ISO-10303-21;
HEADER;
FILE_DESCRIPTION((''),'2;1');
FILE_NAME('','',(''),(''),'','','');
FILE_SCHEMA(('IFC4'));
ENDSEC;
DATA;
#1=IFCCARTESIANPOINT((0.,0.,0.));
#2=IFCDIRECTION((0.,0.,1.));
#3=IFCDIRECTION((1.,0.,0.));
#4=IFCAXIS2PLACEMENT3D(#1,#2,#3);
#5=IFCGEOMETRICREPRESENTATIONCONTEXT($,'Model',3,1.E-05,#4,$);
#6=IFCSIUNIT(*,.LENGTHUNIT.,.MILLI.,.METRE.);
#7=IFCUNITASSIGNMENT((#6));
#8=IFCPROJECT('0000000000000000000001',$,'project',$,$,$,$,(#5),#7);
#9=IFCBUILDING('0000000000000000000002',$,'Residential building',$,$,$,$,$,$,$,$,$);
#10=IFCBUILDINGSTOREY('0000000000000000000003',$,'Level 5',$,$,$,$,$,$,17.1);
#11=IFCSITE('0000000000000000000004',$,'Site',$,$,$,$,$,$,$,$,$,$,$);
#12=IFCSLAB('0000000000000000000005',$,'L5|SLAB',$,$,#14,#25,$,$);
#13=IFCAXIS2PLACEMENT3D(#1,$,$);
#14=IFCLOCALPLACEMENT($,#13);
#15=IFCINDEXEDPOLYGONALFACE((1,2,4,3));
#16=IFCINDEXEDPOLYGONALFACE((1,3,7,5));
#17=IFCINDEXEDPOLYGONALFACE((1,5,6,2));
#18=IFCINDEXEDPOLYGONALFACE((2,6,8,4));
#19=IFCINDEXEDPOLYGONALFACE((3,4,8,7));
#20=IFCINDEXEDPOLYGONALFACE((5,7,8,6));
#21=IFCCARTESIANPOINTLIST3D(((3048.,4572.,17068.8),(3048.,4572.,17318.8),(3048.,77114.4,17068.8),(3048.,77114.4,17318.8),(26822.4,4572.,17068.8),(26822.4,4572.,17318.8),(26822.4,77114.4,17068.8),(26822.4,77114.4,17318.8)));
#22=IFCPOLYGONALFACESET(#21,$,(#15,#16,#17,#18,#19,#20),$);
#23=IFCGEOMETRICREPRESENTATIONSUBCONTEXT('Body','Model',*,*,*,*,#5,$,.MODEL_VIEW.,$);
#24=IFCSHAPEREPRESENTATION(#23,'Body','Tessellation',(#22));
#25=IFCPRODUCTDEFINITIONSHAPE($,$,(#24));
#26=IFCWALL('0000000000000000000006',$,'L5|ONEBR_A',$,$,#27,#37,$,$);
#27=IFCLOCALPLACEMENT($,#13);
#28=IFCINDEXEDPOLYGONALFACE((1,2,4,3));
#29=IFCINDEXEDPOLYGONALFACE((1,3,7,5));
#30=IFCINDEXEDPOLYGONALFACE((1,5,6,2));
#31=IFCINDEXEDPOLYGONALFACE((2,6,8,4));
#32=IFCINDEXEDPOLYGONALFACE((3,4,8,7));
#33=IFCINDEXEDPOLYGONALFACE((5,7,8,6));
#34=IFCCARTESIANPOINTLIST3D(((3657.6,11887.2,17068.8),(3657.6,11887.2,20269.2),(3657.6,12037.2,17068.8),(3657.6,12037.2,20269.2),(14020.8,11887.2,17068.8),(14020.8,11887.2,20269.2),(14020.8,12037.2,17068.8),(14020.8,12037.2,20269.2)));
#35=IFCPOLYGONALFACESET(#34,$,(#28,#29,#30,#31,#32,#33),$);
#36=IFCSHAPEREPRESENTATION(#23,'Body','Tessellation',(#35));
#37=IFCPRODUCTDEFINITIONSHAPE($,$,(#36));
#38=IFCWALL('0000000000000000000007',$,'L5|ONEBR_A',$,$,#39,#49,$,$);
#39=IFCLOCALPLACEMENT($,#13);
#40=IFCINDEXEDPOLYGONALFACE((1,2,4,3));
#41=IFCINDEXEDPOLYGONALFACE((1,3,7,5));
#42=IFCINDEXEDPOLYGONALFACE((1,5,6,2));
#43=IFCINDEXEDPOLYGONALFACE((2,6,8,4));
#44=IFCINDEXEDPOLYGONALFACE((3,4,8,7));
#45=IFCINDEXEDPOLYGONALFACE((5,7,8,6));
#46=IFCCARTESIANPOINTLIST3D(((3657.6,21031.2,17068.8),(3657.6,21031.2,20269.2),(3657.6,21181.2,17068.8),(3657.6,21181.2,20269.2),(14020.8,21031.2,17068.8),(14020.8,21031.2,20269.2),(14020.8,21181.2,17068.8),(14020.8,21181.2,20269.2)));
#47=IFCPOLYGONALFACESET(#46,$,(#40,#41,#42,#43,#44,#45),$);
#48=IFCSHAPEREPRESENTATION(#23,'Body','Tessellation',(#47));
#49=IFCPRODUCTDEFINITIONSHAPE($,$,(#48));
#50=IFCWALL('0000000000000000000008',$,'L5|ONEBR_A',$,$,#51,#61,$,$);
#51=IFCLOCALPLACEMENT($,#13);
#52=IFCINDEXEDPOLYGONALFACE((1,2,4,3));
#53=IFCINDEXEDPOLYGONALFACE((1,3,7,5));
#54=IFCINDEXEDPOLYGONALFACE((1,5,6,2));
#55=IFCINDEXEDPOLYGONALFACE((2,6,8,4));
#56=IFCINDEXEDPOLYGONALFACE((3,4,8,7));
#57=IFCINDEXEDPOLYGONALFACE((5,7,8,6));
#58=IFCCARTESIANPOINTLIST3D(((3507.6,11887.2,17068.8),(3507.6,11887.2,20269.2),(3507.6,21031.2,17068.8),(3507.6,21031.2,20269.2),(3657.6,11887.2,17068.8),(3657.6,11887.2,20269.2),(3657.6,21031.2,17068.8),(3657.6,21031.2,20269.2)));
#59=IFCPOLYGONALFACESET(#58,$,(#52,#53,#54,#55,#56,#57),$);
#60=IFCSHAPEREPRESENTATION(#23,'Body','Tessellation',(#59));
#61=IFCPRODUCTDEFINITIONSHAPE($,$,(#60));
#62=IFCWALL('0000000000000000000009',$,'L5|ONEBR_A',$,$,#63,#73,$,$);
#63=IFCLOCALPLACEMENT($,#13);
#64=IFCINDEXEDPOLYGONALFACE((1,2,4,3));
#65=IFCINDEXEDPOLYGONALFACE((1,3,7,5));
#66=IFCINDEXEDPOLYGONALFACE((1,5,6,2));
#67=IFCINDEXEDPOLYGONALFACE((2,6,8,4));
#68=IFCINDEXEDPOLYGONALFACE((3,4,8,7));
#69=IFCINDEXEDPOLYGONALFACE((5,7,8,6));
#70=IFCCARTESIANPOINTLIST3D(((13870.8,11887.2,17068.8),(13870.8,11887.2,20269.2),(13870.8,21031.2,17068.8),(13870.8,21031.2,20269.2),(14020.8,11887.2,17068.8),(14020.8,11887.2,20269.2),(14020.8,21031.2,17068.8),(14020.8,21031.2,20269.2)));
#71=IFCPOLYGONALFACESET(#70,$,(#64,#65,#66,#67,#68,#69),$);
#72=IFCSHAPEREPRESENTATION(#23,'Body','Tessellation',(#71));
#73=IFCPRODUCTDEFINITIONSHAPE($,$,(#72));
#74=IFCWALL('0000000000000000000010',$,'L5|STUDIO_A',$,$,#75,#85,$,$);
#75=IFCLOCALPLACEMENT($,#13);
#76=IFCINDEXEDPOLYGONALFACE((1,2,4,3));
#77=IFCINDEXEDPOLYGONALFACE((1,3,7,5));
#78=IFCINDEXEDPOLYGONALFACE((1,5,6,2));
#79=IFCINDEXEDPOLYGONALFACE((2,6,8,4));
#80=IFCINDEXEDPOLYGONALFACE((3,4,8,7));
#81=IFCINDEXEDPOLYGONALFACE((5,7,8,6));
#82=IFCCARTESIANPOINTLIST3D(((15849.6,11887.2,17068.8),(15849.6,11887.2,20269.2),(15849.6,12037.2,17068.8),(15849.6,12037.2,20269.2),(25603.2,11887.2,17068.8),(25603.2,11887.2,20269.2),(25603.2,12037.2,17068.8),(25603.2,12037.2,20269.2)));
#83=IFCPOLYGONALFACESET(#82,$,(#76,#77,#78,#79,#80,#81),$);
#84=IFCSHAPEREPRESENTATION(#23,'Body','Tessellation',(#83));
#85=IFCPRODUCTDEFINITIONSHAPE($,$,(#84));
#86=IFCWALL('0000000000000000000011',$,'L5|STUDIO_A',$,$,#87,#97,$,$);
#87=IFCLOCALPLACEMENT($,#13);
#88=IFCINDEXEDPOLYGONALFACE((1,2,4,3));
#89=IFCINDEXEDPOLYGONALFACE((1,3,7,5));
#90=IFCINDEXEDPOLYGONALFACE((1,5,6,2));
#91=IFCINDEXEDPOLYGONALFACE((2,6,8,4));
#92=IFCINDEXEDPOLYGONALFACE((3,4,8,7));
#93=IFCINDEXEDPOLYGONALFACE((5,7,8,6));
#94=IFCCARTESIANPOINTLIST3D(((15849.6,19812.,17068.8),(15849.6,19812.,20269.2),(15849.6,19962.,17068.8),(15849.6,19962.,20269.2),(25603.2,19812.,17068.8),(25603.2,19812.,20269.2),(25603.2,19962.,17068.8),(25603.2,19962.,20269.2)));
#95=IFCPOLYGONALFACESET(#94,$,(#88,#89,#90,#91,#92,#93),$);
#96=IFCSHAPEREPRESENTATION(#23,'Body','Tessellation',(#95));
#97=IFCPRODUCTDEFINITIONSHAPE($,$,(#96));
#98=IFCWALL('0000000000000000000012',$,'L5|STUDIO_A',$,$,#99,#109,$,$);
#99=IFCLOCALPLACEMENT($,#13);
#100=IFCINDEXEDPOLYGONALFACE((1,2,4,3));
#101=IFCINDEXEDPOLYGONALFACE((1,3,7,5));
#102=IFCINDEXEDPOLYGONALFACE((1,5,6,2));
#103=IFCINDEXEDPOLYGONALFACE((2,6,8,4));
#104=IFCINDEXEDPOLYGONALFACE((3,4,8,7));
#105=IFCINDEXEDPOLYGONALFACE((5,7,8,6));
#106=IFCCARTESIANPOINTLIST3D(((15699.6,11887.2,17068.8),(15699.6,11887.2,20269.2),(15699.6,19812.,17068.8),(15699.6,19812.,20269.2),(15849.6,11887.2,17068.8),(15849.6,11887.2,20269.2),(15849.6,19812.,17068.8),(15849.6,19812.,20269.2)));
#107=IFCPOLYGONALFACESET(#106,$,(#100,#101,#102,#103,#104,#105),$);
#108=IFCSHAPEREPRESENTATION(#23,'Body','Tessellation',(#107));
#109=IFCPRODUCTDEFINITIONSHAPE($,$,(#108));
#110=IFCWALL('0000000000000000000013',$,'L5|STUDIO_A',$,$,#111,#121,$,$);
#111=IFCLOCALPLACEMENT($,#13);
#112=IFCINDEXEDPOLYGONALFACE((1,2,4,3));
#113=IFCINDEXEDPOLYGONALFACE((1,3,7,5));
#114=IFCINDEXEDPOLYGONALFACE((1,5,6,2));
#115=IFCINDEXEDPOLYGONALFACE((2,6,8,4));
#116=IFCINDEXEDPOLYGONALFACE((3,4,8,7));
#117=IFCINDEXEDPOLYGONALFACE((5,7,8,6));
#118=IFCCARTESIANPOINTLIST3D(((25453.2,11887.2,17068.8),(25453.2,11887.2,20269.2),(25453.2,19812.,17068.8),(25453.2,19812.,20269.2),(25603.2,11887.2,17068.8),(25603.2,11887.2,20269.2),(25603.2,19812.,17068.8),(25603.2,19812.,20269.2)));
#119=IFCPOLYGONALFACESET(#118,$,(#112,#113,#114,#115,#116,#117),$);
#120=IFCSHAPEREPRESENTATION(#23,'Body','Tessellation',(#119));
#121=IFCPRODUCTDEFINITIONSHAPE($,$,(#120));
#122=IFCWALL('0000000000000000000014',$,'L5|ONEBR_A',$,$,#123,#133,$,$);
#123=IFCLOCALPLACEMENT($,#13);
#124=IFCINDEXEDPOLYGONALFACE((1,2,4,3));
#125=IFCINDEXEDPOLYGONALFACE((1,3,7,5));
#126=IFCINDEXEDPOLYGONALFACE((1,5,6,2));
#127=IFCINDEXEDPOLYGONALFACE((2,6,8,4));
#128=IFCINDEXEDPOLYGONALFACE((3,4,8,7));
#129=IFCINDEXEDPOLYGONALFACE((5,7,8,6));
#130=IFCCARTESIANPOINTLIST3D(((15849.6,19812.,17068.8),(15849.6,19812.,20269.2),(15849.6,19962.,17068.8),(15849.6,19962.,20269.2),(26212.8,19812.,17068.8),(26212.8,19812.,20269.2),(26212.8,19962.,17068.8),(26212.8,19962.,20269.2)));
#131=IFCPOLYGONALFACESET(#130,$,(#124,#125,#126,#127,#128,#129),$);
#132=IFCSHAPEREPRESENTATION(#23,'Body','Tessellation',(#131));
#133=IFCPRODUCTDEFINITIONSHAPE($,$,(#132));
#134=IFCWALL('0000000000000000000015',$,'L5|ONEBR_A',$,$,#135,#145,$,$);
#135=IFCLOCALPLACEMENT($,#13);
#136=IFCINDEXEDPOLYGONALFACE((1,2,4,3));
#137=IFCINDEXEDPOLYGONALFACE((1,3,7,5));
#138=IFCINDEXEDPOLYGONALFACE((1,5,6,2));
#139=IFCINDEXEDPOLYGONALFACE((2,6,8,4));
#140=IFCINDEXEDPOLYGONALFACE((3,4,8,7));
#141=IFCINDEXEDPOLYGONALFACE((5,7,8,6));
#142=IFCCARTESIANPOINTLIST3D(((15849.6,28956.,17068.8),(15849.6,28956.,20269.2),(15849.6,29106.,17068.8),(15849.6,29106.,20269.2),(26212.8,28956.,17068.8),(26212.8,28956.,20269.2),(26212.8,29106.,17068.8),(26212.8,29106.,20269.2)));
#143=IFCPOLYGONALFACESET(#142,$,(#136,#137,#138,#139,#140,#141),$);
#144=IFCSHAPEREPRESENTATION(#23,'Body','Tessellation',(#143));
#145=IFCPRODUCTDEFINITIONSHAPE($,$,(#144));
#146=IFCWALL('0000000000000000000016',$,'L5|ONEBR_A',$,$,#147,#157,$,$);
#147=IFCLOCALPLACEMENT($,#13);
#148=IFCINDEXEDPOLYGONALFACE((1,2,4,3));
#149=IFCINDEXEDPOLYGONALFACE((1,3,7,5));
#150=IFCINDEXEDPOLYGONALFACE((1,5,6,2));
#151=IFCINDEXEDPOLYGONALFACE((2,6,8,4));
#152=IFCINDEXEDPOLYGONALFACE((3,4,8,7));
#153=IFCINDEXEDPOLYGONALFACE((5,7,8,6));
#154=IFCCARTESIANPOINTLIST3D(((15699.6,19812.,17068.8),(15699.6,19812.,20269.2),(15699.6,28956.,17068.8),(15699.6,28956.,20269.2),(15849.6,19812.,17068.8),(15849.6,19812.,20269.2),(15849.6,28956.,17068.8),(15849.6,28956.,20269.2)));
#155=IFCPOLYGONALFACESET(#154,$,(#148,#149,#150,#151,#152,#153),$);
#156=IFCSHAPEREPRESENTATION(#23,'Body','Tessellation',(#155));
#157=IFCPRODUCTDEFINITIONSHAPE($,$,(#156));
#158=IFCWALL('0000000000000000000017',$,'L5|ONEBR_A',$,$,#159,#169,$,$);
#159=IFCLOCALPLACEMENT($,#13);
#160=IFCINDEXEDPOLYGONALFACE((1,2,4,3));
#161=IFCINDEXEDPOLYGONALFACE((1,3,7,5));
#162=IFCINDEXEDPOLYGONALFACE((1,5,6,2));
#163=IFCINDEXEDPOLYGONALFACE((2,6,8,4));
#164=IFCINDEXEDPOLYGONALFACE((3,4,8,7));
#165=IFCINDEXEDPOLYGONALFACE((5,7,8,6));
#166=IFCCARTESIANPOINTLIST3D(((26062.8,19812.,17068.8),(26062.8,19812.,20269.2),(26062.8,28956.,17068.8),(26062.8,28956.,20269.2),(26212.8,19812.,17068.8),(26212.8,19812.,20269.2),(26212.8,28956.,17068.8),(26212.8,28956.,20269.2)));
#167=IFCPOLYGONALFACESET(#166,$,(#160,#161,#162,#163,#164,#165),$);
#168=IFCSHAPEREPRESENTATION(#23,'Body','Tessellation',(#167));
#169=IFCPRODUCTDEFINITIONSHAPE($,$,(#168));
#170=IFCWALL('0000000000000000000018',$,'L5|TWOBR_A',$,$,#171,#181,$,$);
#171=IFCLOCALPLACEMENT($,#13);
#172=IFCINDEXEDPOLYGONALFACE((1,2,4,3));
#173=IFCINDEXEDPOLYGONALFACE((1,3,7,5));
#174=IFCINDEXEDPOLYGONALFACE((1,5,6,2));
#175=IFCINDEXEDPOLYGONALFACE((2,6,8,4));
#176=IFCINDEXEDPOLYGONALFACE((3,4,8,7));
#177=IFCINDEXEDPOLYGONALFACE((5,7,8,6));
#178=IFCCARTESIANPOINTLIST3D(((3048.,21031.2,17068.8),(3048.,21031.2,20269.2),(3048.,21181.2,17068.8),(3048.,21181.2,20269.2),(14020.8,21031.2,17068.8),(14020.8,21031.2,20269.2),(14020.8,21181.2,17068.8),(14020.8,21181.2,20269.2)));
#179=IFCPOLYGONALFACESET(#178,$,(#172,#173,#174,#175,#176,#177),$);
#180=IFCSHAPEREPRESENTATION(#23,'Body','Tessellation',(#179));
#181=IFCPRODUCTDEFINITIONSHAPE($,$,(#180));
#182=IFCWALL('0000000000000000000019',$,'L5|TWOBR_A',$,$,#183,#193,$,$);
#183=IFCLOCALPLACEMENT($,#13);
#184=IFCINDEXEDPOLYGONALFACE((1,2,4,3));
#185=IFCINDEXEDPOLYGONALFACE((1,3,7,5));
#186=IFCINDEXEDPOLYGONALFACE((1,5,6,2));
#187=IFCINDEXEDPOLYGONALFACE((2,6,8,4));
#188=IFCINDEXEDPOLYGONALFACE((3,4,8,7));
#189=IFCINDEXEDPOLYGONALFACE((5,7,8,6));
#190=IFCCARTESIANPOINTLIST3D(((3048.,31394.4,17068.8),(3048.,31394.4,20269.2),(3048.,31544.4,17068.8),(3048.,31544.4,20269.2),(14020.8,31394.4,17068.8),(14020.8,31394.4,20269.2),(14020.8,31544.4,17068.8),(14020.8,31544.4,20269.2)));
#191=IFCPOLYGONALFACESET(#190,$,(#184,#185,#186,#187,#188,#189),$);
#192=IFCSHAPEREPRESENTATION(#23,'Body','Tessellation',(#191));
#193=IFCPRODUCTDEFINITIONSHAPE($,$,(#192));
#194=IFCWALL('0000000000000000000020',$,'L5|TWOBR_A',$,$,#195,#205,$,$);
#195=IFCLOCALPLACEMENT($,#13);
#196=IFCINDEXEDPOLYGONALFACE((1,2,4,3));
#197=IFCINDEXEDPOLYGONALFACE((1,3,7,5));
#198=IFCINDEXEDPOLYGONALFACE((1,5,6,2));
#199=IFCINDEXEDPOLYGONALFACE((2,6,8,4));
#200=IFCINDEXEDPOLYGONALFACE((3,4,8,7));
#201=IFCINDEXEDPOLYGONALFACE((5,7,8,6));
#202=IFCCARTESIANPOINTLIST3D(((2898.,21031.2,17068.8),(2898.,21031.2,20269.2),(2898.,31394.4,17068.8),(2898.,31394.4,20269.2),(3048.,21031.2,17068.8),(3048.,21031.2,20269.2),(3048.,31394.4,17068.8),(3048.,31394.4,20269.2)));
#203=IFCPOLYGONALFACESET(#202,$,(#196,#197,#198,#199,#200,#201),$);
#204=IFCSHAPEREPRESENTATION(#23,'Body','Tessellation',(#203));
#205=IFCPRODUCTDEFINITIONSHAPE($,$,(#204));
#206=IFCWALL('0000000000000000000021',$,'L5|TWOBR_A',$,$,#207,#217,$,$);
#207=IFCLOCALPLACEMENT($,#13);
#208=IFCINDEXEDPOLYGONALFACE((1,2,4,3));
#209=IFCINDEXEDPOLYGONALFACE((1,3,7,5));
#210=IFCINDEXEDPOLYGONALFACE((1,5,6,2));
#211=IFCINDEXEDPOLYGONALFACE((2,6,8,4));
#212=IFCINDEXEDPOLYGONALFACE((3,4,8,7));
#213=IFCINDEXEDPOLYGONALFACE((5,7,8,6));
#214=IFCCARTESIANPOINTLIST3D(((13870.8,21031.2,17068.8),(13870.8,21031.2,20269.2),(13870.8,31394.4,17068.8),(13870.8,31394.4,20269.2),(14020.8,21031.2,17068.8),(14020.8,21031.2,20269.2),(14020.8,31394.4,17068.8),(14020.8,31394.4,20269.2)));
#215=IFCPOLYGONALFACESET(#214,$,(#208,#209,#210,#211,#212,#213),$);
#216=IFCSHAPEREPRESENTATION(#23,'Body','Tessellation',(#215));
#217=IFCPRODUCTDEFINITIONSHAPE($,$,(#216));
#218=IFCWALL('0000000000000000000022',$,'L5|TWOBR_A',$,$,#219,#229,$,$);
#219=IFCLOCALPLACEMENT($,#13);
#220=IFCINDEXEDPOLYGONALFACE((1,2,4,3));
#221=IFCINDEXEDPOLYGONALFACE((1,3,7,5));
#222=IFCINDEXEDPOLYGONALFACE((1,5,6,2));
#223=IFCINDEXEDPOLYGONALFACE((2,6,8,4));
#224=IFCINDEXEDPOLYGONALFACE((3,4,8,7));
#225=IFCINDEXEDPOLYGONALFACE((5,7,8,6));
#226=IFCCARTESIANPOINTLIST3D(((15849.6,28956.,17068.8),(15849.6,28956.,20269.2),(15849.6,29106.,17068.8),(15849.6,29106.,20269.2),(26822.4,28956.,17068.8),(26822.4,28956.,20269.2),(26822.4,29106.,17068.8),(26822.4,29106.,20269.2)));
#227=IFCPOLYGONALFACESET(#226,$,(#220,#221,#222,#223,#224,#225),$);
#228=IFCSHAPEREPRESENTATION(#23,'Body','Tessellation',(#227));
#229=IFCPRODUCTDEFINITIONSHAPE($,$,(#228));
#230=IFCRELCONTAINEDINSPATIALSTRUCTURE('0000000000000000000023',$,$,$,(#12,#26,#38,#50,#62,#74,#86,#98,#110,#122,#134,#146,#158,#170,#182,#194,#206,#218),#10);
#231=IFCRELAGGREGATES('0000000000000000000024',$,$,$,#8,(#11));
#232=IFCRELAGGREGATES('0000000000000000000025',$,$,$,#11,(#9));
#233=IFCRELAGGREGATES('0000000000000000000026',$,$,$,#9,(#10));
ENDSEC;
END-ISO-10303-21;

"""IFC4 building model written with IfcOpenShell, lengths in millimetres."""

from ifc_helpers import new_model, si_unit, frame, origin_with_axes, place, context, subcontext, project, spatial, indexed_curve, outline, extrude, element, save


model = new_model("IFC4")

# Units and contexts
model_context = context("Model", 3, precision=1e-05, world=origin_with_axes())
body_context = subcontext(model_context, "Body", "Model", "MODEL_VIEW")
ifc_project = project(units=[si_unit("LENGTHUNIT", "METRE", prefix="MILLI")], contexts=[model_context])

# Site, building, storey
site = spatial("IfcSite", under=ifc_project, Name="Site")
building = spatial("IfcBuilding", under=site, Name="Residential building")
storey = spatial("IfcBuildingStorey", under=building, Name="Level 5", Elevation=17.1)

# Slab
slab_placement = place(None, frame((3048.0, 4572.0, 17068.8), z_axis=(0.0, 0.0, 1.0), x_axis=(1.0, 0.0, 0.0)))
element("IfcSlab", 1, at=slab_placement, inside=storey, Name="L5|SLAB", context=body_context, shape_type="SweptSolid", body=[
    extrude(outline(indexed_curve([(0.0, 0.0), (23774.4, 0.0), (23774.4, 72542.4), (0.0, 72542.4), (0.0, 0.0)])), None, (0.0, 0.0, 1.0), 250.0),
])

# Walls
for number, where, z_axis, x_axis, name in (
    (2, (3657.6, 11887.2, 17068.8), (0.0, 0.0, 1.0), (1.0, 0.0, 0.0), "L5|ONEBR_A"),
    (3, (3657.6, 21031.2, 17068.8), (0.0, 0.0, 1.0), (1.0, 0.0, 0.0), "L5|ONEBR_A"),
):
    element("IfcWall", number, at=place(None, frame(where, z_axis=z_axis, x_axis=x_axis)), inside=storey, Name=name, context=body_context, shape_type="SweptSolid", body=[
        extrude(outline(indexed_curve([(0.0, 0.0), (0.0, 150.0), (10363.2, 150.0), (10363.2, 0.0), (0.0, 0.0)], self_intersect=False)), origin_with_axes(), (0.0, 0.0, 1.0), 3200.4),
    ])
for number, where, z_axis, x_axis, name in (
    (4, (3657.6, 11887.2, 17068.8), (0.0, 0.0, 1.0), (0.0, 1.0, 0.0), "L5|ONEBR_A"),
    (5, (14020.8, 11887.2, 17068.8), (0.0, 0.0, 1.0), (0.0, 1.0, 0.0), "L5|ONEBR_A"),
):
    element("IfcWall", number, at=place(None, frame(where, z_axis=z_axis, x_axis=x_axis)), inside=storey, Name=name, context=body_context, shape_type="SweptSolid", body=[
        extrude(outline(indexed_curve([(0.0, 0.0), (0.0, 150.0), (9144.0, 150.0), (9144.0, 0.0), (0.0, 0.0)], self_intersect=False)), origin_with_axes(), (0.0, 0.0, 1.0), 3200.4),
    ])
for number, where, z_axis, x_axis, name in (
    (6, (15849.6, 11887.2, 17068.8), (0.0, 0.0, 1.0), (1.0, 0.0, 0.0), "L5|STUDIO_A"),
    (7, (15849.6, 19812.0, 17068.8), (0.0, 0.0, 1.0), (1.0, 0.0, 0.0), "L5|STUDIO_A"),
):
    element("IfcWall", number, at=place(None, frame(where, z_axis=z_axis, x_axis=x_axis)), inside=storey, Name=name, context=body_context, shape_type="SweptSolid", body=[
        extrude(outline(indexed_curve([(0.0, 0.0), (0.0, 150.0), (9753.6, 150.0), (9753.6, 0.0), (0.0, 0.0)], self_intersect=False)), origin_with_axes(), (0.0, 0.0, 1.0), 3200.4),
    ])
for number, where, z_axis, x_axis, name in (
    (8, (15849.6, 11887.2, 17068.8), (0.0, 0.0, 1.0), (0.0, 1.0, 0.0), "L5|STUDIO_A"),
    (9, (25603.2, 11887.2, 17068.8), (0.0, 0.0, 1.0), (0.0, 1.0, 0.0), "L5|STUDIO_A"),
):
    element("IfcWall", number, at=place(None, frame(where, z_axis=z_axis, x_axis=x_axis)), inside=storey, Name=name, context=body_context, shape_type="SweptSolid", body=[
        extrude(outline(indexed_curve([(0.0, 0.0), (0.0, 150.0), (7924.8, 150.0), (7924.8, 0.0), (0.0, 0.0)], self_intersect=False)), origin_with_axes(), (0.0, 0.0, 1.0), 3200.4),
    ])
for number, where, z_axis, x_axis, name in (
    (10, (15849.6, 19812.0, 17068.8), (0.0, 0.0, 1.0), (1.0, 0.0, 0.0), "L5|ONEBR_A"),
    (11, (15849.6, 28956.0, 17068.8), (0.0, 0.0, 1.0), (1.0, 0.0, 0.0), "L5|ONEBR_A"),
):
    element("IfcWall", number, at=place(None, frame(where, z_axis=z_axis, x_axis=x_axis)), inside=storey, Name=name, context=body_context, shape_type="SweptSolid", body=[
        extrude(outline(indexed_curve([(0.0, 0.0), (0.0, 150.0), (10363.2, 150.0), (10363.2, 0.0), (0.0, 0.0)], self_intersect=False)), origin_with_axes(), (0.0, 0.0, 1.0), 3200.4),
    ])
for number, where, z_axis, x_axis, name in (
    (12, (15849.6, 19812.0, 17068.8), (0.0, 0.0, 1.0), (0.0, 1.0, 0.0), "L5|ONEBR_A"),
    (13, (26212.8, 19812.0, 17068.8), (0.0, 0.0, 1.0), (0.0, 1.0, 0.0), "L5|ONEBR_A"),
):
    element("IfcWall", number, at=place(None, frame(where, z_axis=z_axis, x_axis=x_axis)), inside=storey, Name=name, context=body_context, shape_type="SweptSolid", body=[
        extrude(outline(indexed_curve([(0.0, 0.0), (0.0, 150.0), (9144.0, 150.0), (9144.0, 0.0), (0.0, 0.0)], self_intersect=False)), origin_with_axes(), (0.0, 0.0, 1.0), 3200.4),
    ])
for number, where, z_axis, x_axis, name in (
    (14, (3048.0, 21031.2, 17068.8), (0.0, 0.0, 1.0), (1.0, 0.0, 0.0), "L5|TWOBR_A"),
    (15, (3048.0, 31394.4, 17068.8), (0.0, 0.0, 1.0), (1.0, 0.0, 0.0), "L5|TWOBR_A"),
):
    element("IfcWall", number, at=place(None, frame(where, z_axis=z_axis, x_axis=x_axis)), inside=storey, Name=name, context=body_context, shape_type="SweptSolid", body=[
        extrude(outline(indexed_curve([(0.0, 0.0), (0.0, 150.0), (10972.8, 150.0), (10972.8, 0.0), (0.0, 0.0)], self_intersect=False)), origin_with_axes(), (0.0, 0.0, 1.0), 3200.4),
    ])
for number, where, z_axis, x_axis, name in (
    (16, (3048.0, 21031.2, 17068.8), (0.0, 0.0, 1.0), (0.0, 1.0, 0.0), "L5|TWOBR_A"),
    (17, (14020.8, 21031.2, 17068.8), (0.0, 0.0, 1.0), (0.0, 1.0, 0.0), "L5|TWOBR_A"),
):
    element("IfcWall", number, at=place(None, frame(where, z_axis=z_axis, x_axis=x_axis)), inside=storey, Name=name, context=body_context, shape_type="SweptSolid", body=[
        extrude(outline(indexed_curve([(0.0, 0.0), (0.0, 150.0), (10363.2, 150.0), (10363.2, 0.0), (0.0, 0.0)], self_intersect=False)), origin_with_axes(), (0.0, 0.0, 1.0), 3200.4),
    ])
wall_1_placement = place(None, frame((15849.6, 28956.0, 17068.8), z_axis=(0.0, 0.0, 1.0), x_axis=(1.0, 0.0, 0.0)))
element("IfcWall", 18, at=wall_1_placement, inside=storey, Name="L5|TWOBR_A", context=body_context, shape_type="SweptSolid", body=[
    extrude(outline(indexed_curve([(0.0, 0.0), (0.0, 150.0), (10972.8, 150.0), (10972.8, 0.0), (0.0, 0.0)], self_intersect=False)), origin_with_axes(), (0.0, 0.0, 1.0), 3200.4),
])

save(model, "model.ifc")
